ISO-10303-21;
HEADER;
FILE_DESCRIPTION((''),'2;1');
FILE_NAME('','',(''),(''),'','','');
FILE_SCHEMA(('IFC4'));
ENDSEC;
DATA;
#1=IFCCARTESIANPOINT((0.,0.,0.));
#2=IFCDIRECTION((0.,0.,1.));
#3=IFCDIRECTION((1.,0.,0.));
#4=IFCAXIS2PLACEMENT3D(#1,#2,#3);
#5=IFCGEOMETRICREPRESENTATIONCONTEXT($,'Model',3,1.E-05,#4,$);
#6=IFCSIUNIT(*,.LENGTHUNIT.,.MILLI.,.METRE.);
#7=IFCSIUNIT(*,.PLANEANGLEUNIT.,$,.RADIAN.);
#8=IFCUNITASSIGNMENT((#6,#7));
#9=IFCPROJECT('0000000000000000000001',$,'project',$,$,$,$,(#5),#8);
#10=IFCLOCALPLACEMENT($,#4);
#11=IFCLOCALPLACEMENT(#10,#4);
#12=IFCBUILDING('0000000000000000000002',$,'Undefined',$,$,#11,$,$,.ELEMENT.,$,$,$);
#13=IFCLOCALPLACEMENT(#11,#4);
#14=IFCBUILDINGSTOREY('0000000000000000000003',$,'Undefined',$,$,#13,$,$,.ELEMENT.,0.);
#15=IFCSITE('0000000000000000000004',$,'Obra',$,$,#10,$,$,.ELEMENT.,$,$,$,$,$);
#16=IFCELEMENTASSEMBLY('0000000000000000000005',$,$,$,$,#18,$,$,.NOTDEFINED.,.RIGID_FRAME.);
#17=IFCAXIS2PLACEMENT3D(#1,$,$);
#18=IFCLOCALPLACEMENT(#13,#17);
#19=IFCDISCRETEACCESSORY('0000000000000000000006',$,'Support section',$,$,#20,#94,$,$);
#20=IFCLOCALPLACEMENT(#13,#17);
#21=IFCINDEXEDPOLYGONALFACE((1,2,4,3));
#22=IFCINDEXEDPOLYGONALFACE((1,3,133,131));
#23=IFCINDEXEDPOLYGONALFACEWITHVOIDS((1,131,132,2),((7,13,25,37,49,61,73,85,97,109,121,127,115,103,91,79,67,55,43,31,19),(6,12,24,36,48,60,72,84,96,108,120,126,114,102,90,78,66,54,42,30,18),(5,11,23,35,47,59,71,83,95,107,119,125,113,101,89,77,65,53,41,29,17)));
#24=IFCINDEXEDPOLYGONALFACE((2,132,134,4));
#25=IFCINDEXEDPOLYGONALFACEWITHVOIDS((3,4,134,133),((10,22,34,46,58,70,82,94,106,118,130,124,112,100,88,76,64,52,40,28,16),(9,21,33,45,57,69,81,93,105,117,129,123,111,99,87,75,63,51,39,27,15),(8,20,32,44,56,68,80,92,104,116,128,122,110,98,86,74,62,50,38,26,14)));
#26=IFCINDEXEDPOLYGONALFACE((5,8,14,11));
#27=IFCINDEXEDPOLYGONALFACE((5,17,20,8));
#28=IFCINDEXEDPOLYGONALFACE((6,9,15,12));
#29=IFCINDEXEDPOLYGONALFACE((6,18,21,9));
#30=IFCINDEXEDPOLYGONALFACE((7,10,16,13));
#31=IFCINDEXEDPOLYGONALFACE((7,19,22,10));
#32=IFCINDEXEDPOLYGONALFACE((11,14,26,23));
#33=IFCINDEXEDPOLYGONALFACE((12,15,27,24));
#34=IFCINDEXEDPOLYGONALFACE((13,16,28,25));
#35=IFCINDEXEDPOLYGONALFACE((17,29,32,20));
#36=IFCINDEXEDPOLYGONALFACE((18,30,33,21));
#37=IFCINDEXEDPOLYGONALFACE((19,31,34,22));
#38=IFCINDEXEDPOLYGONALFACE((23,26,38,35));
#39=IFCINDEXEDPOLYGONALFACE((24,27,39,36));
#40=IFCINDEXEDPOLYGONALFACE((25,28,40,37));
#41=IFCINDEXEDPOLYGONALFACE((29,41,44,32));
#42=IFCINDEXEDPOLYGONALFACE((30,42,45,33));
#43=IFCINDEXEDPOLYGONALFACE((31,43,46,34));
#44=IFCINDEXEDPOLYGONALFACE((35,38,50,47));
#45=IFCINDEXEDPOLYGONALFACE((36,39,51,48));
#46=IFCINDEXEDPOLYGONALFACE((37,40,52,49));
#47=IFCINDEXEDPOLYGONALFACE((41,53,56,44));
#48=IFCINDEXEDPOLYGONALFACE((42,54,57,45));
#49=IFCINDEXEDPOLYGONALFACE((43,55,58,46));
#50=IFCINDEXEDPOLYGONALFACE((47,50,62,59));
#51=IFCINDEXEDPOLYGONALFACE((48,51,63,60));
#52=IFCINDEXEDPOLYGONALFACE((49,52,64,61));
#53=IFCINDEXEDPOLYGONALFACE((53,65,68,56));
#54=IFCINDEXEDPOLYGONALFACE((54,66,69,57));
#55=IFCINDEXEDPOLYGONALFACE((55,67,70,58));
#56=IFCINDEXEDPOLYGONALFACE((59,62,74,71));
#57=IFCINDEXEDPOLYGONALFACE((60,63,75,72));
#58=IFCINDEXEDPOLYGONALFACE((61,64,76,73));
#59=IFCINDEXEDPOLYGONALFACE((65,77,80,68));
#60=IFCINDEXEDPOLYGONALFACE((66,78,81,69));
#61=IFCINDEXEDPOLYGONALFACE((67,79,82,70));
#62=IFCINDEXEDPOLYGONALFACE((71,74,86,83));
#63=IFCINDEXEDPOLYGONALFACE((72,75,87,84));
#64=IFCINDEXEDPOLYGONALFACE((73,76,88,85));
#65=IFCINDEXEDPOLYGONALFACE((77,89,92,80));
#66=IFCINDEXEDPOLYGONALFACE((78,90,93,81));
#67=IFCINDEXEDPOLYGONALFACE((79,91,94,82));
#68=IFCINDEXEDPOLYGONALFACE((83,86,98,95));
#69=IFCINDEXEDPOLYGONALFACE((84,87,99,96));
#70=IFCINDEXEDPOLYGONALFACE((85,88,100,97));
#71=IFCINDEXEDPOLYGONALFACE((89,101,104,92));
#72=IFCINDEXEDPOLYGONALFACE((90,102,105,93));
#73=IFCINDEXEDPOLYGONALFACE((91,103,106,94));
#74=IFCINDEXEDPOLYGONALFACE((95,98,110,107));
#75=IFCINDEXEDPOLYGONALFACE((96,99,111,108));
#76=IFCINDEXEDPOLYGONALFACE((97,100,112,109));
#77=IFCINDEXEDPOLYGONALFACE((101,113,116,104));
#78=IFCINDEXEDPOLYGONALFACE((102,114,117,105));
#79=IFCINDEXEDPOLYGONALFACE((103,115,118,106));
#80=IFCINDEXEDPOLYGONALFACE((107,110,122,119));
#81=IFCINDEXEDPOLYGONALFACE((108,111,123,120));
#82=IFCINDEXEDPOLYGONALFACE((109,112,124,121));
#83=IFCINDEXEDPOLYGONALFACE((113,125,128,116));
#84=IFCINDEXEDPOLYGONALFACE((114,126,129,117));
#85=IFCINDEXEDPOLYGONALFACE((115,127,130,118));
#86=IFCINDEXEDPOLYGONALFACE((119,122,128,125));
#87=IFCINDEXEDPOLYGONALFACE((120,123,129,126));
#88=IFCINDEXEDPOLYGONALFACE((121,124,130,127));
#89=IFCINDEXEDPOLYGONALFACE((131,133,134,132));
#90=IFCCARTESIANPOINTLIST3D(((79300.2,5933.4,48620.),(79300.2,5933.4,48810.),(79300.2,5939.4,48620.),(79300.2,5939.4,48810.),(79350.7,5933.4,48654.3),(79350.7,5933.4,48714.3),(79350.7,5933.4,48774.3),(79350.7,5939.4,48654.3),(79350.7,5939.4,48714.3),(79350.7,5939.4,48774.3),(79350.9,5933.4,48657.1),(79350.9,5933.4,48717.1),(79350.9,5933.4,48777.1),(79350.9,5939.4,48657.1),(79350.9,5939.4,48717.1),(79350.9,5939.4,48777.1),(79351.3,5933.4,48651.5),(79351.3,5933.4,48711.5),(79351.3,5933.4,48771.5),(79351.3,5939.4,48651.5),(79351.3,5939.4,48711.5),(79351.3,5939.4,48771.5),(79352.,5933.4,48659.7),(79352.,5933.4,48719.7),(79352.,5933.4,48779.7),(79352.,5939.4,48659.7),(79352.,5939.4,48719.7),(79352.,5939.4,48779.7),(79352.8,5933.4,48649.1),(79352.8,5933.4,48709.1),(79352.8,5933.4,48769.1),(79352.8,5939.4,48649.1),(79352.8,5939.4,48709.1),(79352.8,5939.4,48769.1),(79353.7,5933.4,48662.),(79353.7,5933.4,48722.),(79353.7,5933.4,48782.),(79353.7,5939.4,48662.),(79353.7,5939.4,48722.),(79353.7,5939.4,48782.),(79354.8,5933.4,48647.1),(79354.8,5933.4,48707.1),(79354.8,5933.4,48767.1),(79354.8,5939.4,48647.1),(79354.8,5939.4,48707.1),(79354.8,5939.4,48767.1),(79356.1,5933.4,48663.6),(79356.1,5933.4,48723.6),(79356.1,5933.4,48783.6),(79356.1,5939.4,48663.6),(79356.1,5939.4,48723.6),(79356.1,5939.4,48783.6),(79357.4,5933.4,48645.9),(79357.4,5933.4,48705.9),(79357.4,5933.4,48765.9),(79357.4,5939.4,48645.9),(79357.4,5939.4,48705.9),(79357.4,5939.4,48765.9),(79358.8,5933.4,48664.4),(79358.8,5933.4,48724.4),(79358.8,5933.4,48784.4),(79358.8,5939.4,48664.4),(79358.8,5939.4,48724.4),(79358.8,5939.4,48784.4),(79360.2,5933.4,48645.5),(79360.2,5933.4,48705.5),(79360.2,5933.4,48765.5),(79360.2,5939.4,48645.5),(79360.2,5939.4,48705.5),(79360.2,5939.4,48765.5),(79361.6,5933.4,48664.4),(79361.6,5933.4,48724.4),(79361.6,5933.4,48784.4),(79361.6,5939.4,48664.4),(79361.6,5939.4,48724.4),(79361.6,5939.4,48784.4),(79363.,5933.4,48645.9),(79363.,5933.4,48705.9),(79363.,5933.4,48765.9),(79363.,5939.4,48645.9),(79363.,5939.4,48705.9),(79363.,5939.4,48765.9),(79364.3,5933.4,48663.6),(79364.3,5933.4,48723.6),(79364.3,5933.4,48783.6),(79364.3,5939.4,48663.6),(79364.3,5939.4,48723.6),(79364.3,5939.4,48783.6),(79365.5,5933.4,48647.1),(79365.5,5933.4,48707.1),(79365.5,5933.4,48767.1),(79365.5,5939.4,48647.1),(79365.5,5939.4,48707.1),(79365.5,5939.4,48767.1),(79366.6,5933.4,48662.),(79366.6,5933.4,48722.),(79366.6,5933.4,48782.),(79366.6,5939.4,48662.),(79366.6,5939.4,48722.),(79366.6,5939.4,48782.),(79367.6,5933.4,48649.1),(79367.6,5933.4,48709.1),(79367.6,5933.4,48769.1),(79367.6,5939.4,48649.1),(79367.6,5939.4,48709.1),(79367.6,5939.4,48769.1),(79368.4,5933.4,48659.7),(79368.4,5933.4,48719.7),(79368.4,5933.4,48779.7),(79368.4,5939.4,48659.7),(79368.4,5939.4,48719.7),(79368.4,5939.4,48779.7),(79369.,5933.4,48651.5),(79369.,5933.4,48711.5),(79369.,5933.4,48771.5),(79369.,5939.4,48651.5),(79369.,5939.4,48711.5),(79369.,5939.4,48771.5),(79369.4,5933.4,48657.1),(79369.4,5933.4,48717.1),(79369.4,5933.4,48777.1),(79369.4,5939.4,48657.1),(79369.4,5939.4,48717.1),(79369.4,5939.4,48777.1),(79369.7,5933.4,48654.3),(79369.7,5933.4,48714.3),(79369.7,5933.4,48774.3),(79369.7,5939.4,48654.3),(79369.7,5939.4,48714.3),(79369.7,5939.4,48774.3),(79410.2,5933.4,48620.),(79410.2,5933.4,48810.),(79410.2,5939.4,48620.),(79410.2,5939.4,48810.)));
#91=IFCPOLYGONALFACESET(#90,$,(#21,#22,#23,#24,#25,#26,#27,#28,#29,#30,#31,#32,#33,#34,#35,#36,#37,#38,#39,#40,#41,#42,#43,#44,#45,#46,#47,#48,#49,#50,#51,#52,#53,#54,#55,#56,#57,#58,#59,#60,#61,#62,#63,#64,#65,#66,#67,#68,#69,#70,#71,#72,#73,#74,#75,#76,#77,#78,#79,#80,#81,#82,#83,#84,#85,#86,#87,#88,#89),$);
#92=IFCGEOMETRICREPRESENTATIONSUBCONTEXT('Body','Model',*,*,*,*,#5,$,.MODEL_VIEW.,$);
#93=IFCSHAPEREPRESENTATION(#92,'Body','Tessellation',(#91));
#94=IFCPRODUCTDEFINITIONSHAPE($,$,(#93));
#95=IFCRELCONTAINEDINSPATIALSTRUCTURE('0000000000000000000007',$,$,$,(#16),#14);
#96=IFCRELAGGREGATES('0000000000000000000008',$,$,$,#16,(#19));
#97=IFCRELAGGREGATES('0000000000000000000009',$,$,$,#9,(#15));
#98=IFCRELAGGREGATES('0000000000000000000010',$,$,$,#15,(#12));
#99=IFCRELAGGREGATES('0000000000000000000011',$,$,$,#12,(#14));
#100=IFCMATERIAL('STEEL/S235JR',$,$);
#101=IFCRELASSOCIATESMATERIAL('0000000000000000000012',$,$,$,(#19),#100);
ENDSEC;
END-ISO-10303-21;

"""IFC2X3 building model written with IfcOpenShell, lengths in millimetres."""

from ifc_helpers import new_model, si_unit, frame, origin_with_axes, origin_2d_with_axis, place, context, subcontext, project, spatial, rectangle, circle, extrude, source, transform, mapped, material, element, aggregate, save


model = new_model("IFC2X3")

# Units and contexts
model_context = context("Model", 3, precision=1e-05, world=origin_with_axes())
body_context = subcontext(model_context, "Body", "Model", "MODEL_VIEW")
ifc_project = project(units=[si_unit("LENGTHUNIT", "METRE", prefix="MILLI"), si_unit("PLANEANGLEUNIT", "RADIAN")], contexts=[model_context])

# Site, building, storey
site_placement = place(None, origin_with_axes())
site = spatial("IfcSite", under=ifc_project, at=site_placement, Name="Obra", CompositionType="ELEMENT")
building_placement = place(site_placement, origin_with_axes())
building = spatial("IfcBuilding", under=site, at=building_placement, Name="Undefined", CompositionType="ELEMENT")
storey_placement = place(building_placement, origin_with_axes())
storey = spatial("IfcBuildingStorey", under=building, at=storey_placement, Name="Undefined", CompositionType="ELEMENT", Elevation=0.0)

# Element assembly
assembly_1_placement = place(storey_placement, origin_with_axes())
assembly_1 = element("IfcElementAssembly", 1, at=assembly_1_placement, inside=storey, AssemblyPlace="NOTDEFINED", PredefinedType="RIGID_FRAME")
ifc_material_1 = material(Name="STEEL/S235JR")

# Discrete accessory, opening
discrete_accessory_placement = place(assembly_1_placement, frame((79355.2, 5936.4, 48620.0), z_axis=(0.0, 0.0, 1.0), x_axis=(-1.0, 0.0, 0.0)))
discrete_accessory = element("IfcDiscreteAccessory", 2, at=discrete_accessory_placement, material=ifc_material_1, Name="Support section", context=body_context, shape_type="SweptSolid", body=[
    extrude(rectangle(XDim=6.0, YDim=110.0, at=origin_2d_with_axis()), frame((0.0, 0.0, 190.0), z_axis=(0.0, 0.0, -1.0), x_axis=(0.0, 1.0, 0.0)), (0.0, 0.0, 1.0), 190.0),
])
shared_shape_1 = source(origin_with_axes(), body_context, "Body", "SweptSolid", [
    extrude(circle(Radius=9.5, at=origin_2d_with_axis()), frame((0.0, -9.2, 0.0), z_axis=(0.0, 1.0, 0.0), x_axis=(1.0, 0.0, 0.0)), (0.0, 0.0, 1.0), 6.2),
])
opening_1_placement = place(assembly_1_placement, frame((79310.2, 5942.5, 48835.0), z_axis=(1.0, 0.0, 0.0), x_axis=(0.0, 0.0, -1.0)))
element("IfcOpeningElement", 3, at=opening_1_placement, cuts=discrete_accessory, ObjectType="Opening", context=body_context, shape_type="MappedRepresentation", body=[
    mapped(shared_shape_1, transform((60.0, 0.0, 50.0))),
    mapped(shared_shape_1, transform((120.0, 0.0, 50.0))),
    mapped(shared_shape_1, transform((180.0, 0.0, 50.0))),
])
aggregate(assembly_1, [discrete_accessory])

save(model, "model.ifc")
